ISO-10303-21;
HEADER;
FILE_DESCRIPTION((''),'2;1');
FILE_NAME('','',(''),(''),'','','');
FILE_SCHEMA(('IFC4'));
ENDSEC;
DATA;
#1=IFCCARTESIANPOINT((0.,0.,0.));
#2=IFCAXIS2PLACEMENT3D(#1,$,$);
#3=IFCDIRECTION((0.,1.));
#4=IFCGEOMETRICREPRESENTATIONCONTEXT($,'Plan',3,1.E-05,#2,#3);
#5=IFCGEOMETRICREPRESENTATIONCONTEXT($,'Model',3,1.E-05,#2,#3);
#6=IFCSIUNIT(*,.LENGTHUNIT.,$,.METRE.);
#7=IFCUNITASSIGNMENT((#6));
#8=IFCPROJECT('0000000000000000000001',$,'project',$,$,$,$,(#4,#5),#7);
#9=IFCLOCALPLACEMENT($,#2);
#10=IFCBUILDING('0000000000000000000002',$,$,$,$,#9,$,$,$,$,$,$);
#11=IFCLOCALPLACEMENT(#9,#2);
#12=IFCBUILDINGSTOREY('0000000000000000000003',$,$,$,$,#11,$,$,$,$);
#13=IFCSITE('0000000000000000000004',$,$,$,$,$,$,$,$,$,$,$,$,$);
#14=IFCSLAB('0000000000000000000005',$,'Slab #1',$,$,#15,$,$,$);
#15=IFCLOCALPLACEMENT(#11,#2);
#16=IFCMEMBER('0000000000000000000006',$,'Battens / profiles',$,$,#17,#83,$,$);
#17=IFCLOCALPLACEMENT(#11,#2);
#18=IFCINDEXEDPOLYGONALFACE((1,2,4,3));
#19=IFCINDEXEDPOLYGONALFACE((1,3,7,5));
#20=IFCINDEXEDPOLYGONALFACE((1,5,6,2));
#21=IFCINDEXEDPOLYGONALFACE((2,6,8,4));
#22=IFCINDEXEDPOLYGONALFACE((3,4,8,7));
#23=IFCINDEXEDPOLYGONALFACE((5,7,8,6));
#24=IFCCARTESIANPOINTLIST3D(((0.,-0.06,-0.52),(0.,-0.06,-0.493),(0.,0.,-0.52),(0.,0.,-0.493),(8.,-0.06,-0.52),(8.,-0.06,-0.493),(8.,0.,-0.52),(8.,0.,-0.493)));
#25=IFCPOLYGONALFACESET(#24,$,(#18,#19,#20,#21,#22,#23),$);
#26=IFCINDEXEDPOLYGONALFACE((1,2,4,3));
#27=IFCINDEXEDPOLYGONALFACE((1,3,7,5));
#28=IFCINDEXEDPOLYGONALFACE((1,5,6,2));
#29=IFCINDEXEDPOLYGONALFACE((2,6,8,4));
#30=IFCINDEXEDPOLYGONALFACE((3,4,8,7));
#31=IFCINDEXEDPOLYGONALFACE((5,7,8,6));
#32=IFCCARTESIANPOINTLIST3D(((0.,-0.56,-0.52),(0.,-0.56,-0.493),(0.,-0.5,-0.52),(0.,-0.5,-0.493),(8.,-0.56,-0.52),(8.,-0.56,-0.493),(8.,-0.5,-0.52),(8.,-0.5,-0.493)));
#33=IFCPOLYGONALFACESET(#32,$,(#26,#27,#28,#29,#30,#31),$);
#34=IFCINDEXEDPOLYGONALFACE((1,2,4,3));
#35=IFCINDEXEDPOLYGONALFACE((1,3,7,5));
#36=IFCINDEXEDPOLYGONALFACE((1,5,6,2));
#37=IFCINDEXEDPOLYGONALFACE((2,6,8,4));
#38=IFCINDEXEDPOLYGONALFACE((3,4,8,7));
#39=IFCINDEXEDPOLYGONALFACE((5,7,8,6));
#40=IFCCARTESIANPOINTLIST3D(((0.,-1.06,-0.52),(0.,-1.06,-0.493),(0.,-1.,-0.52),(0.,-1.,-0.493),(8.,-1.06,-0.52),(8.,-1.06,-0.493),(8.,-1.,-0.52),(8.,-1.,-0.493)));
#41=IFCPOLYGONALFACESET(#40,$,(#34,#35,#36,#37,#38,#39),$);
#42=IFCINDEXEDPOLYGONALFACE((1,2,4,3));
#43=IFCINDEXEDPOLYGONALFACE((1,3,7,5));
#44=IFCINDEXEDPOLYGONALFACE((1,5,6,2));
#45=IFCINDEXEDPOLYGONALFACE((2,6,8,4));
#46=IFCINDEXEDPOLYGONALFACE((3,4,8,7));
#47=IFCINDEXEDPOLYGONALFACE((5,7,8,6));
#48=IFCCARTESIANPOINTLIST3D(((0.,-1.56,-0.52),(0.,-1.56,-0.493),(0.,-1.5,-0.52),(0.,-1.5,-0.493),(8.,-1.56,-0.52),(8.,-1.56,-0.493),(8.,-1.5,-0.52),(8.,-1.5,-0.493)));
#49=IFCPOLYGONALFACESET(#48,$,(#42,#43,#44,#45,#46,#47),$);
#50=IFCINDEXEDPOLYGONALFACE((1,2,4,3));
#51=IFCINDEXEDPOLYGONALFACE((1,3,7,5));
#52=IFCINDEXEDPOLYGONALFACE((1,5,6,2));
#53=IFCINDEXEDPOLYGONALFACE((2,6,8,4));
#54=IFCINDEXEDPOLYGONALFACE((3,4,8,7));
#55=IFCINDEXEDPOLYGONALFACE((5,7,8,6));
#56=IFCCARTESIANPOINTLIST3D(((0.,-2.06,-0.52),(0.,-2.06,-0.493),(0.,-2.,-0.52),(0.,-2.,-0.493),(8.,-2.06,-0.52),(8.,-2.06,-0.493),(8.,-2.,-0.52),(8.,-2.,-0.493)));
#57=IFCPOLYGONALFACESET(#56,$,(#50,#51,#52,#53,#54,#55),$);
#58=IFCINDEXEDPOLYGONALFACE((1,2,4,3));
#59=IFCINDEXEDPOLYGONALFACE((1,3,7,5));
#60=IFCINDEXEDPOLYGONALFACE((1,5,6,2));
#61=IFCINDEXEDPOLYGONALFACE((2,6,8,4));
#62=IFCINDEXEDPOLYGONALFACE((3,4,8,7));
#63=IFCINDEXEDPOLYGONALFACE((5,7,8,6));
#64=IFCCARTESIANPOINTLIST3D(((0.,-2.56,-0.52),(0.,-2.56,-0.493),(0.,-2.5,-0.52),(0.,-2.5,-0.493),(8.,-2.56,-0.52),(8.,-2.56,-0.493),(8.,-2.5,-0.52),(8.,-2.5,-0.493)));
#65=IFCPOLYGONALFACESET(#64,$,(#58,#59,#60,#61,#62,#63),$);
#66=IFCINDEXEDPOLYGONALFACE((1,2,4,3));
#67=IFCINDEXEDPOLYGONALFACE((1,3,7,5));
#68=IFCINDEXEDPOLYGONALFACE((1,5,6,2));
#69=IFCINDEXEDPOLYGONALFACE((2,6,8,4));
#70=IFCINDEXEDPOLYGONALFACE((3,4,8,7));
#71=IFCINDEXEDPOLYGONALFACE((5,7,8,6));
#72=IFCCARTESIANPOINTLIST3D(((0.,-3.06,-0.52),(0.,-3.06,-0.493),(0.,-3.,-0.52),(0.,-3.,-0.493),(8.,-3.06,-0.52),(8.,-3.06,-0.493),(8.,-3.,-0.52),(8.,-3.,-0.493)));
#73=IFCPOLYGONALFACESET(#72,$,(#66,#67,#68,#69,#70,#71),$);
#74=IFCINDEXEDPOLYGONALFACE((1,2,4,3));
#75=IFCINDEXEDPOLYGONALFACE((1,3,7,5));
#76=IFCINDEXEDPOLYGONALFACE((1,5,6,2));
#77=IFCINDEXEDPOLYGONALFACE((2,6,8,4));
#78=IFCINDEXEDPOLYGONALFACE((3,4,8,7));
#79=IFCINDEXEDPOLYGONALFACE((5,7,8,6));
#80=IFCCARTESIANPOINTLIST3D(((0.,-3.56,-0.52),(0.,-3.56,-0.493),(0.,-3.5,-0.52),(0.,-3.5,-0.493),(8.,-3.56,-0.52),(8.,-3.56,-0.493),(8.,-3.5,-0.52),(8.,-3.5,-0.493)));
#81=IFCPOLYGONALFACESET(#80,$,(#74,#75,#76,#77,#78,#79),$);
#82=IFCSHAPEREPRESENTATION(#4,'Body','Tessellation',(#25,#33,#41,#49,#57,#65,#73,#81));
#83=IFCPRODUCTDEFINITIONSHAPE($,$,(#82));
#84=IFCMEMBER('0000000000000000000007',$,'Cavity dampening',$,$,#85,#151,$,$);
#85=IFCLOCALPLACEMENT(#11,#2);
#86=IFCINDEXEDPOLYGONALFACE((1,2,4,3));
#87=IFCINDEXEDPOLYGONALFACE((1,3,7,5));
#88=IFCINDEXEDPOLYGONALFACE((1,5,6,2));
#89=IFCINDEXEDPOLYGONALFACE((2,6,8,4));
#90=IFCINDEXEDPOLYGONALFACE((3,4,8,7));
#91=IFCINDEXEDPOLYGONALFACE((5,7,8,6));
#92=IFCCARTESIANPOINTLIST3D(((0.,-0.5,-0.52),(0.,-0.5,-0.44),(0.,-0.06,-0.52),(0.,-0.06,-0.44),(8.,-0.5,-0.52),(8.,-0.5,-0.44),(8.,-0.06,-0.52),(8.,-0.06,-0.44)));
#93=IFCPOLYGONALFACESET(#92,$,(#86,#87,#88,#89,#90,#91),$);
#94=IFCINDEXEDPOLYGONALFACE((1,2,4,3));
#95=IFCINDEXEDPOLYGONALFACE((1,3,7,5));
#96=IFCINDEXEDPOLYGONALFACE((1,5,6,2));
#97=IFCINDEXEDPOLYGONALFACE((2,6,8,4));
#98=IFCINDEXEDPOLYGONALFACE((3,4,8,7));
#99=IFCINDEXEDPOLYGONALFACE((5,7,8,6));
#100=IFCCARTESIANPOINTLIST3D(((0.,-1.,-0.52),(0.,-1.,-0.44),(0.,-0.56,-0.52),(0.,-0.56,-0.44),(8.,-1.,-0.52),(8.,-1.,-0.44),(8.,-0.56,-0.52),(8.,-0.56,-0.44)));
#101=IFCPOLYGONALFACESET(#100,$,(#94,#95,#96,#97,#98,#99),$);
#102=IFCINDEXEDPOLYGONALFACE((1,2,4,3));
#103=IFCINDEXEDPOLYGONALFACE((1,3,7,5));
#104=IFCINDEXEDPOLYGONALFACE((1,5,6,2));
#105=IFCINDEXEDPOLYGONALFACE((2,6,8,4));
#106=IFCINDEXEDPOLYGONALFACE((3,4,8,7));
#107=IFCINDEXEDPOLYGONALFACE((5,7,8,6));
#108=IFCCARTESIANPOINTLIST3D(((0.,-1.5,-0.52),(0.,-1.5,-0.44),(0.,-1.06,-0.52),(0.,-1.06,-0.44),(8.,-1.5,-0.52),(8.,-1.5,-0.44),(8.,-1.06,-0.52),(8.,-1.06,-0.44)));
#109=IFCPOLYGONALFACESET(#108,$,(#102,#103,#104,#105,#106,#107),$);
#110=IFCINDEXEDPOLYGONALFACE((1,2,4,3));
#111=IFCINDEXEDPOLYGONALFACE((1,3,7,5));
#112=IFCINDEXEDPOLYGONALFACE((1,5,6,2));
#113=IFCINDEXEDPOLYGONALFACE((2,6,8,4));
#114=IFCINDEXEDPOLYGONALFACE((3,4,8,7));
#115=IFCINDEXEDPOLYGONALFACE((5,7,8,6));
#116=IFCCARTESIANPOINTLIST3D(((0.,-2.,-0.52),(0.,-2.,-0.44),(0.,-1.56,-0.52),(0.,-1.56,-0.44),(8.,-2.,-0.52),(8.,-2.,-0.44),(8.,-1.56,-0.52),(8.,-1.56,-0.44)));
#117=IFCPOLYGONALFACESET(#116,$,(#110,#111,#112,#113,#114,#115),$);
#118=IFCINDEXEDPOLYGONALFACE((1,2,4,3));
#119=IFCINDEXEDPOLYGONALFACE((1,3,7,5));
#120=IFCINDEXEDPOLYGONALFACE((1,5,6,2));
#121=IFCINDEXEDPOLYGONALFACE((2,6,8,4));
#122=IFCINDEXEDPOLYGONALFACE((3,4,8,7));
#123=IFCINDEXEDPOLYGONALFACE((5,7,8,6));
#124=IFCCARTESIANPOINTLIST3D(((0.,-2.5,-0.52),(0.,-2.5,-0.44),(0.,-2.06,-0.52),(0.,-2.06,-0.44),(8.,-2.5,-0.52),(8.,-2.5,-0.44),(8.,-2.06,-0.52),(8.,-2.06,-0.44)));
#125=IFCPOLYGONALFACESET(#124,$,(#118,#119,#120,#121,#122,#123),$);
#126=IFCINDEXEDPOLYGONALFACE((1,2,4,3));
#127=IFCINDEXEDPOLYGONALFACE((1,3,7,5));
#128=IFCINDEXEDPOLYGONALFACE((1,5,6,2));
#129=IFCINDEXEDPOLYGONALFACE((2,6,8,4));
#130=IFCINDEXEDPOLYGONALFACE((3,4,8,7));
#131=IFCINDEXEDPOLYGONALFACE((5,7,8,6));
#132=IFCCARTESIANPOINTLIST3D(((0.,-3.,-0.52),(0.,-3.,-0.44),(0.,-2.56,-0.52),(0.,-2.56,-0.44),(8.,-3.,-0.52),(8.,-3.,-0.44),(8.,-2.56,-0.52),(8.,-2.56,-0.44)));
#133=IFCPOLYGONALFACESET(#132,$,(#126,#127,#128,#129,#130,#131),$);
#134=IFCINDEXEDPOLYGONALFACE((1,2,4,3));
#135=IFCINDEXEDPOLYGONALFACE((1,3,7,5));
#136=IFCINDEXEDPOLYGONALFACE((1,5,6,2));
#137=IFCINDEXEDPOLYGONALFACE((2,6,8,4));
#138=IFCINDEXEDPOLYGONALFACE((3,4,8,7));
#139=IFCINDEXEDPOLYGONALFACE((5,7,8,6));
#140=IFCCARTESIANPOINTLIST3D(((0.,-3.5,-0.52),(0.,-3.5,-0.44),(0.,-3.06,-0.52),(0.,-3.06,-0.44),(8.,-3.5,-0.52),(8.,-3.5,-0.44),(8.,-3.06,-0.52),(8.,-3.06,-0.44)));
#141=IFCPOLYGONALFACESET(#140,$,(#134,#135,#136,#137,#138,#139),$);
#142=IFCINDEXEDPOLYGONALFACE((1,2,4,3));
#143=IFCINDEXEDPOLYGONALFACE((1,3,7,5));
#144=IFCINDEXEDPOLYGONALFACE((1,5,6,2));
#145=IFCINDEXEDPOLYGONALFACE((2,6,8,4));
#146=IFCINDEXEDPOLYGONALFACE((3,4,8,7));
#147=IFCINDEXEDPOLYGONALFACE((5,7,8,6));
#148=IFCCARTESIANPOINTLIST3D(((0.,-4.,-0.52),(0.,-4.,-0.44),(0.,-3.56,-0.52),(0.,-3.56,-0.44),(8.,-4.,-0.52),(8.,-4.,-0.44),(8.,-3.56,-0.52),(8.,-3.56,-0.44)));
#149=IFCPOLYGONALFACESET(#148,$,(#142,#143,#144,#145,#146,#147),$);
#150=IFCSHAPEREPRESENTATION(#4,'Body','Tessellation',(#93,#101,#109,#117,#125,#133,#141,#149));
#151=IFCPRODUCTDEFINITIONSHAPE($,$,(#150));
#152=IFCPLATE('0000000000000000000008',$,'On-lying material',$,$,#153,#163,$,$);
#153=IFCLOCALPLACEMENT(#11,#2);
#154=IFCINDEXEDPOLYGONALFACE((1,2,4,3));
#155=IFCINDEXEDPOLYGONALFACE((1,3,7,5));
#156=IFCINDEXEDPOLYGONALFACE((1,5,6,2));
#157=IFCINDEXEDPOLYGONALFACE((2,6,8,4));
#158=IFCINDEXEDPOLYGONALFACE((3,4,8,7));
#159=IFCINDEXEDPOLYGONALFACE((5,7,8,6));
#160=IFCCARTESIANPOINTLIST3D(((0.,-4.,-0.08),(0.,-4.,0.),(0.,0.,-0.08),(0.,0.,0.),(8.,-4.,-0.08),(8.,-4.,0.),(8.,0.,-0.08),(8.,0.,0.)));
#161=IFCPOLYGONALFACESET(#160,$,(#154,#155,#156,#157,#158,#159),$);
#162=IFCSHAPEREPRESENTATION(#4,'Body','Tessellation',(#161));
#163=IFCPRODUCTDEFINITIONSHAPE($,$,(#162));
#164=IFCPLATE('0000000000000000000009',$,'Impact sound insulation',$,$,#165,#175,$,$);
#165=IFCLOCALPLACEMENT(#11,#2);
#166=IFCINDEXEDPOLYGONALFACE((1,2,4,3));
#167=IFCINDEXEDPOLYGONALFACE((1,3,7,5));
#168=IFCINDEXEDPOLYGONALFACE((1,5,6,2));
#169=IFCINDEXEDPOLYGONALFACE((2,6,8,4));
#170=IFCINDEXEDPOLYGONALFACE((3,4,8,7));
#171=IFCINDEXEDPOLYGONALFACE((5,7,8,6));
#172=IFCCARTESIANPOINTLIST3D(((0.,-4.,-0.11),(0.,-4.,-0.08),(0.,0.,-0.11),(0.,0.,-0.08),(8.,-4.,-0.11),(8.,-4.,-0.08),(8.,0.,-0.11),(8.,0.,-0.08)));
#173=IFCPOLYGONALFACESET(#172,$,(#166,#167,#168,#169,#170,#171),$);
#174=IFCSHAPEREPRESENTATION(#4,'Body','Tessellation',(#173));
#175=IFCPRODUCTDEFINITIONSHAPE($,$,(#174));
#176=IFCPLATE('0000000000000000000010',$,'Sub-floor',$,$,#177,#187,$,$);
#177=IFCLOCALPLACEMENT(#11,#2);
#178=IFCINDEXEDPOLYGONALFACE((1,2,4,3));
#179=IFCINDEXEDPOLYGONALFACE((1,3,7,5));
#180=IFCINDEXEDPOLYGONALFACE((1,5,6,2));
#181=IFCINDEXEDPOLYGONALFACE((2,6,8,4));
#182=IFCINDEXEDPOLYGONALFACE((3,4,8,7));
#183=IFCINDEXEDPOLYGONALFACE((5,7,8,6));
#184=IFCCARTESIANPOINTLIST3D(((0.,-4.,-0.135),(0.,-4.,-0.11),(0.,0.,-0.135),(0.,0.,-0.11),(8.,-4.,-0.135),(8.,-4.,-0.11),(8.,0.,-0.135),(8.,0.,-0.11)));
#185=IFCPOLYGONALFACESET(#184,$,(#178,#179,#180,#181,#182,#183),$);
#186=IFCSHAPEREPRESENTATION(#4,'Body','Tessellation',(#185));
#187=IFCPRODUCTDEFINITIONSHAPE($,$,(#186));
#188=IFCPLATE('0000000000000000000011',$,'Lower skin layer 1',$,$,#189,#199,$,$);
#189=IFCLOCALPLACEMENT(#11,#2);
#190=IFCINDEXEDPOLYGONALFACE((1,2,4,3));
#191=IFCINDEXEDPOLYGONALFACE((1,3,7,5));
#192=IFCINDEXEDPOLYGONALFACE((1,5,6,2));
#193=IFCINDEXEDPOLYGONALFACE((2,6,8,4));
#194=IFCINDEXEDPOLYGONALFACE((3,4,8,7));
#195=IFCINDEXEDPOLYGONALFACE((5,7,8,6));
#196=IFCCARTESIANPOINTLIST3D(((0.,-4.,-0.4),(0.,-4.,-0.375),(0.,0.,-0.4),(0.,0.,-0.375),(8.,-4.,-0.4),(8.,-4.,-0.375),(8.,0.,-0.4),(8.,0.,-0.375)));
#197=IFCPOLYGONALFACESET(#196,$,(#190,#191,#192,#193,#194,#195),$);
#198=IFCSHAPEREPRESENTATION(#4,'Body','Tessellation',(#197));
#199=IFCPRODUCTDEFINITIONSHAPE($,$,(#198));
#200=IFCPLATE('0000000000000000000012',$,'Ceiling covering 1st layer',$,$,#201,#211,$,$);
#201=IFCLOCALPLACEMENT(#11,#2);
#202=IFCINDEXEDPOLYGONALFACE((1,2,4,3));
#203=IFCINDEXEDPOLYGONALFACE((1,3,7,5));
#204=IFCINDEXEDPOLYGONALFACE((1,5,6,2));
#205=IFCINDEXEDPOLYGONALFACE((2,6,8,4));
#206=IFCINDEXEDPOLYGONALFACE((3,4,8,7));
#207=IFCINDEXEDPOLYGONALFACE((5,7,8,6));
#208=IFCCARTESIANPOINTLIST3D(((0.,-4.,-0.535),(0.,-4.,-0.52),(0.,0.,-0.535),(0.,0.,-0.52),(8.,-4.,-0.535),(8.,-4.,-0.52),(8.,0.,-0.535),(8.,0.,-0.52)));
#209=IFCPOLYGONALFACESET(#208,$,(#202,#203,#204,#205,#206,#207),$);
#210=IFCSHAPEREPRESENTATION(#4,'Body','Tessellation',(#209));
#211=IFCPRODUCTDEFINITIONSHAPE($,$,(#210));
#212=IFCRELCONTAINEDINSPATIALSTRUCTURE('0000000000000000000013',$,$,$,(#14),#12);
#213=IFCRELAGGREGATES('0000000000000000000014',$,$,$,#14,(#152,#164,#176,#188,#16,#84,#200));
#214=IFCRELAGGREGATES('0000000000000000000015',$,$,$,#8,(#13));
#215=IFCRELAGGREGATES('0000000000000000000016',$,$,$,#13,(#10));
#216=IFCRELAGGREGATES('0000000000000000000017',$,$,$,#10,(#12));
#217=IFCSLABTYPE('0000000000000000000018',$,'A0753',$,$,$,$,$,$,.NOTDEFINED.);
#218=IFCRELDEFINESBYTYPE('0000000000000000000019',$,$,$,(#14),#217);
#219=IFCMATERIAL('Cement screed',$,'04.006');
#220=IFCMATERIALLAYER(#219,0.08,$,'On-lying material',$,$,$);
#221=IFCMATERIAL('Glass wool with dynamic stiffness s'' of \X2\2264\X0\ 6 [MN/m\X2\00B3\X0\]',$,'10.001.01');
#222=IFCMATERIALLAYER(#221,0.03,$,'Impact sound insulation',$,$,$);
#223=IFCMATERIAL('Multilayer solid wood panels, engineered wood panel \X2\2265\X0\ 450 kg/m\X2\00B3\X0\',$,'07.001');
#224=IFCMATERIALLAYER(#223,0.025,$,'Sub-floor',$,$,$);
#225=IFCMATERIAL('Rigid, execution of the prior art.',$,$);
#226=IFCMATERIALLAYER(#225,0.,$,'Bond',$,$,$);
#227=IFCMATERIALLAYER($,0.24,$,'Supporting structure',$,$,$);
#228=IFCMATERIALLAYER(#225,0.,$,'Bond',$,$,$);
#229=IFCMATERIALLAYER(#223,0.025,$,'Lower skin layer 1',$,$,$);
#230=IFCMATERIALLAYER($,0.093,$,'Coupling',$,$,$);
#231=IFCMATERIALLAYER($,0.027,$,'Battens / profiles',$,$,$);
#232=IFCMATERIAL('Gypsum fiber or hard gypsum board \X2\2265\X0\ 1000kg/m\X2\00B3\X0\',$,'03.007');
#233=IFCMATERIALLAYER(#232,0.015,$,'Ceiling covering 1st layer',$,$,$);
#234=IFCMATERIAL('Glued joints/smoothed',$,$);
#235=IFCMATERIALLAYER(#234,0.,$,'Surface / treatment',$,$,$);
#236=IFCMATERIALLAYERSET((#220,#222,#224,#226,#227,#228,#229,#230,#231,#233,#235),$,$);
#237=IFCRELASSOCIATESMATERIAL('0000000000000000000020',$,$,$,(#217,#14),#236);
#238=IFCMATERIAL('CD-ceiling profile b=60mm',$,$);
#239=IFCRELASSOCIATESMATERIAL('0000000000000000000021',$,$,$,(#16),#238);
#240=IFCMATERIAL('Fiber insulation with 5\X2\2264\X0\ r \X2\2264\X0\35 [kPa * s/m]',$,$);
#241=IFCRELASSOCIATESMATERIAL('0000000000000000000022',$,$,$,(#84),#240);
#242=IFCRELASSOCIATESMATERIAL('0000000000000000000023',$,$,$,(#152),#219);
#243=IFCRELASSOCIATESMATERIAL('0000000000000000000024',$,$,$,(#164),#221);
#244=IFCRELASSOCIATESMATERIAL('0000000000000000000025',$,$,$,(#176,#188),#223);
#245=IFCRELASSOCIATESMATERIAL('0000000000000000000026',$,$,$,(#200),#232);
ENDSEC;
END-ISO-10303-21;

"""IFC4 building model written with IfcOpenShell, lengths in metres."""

from ifc_helpers import new_model, si_unit, direction, frame, frame_2d, origin, origin_with_axes, place, context, project, spatial, rectangle, extrude, material, layer, layer_set, type_object, element, aggregate, save


model = new_model("IFC4")

# Units and contexts
plan_context = context("Plan", 3, precision=1e-05, world=origin(), true_north=direction((0.0, 1.0)))
model_context = context("Model", 3, precision=1e-05, world=origin(), true_north=direction((0.0, 1.0)))
ifc_project = project(units=[si_unit("LENGTHUNIT", "METRE")], contexts=[plan_context, model_context])

# Site, building, storey
site = spatial("IfcSite", under=ifc_project)
building_placement = place(None, origin())
building = spatial("IfcBuilding", under=site, at=building_placement)
storey_placement = place(building_placement, origin())
storey = spatial("IfcBuildingStorey", under=building, at=storey_placement)

# Slab, members, plates
ifc_material_1 = material(Name="Cement screed", Category="04.006")
ifc_layer_1 = layer(ifc_material_1, 0.08, Name="On-lying material")
ifc_material_2 = material(Name="Glass wool with dynamic stiffness s' of ≤ 6 [MN/m³]", Category="10.001.01")
ifc_layer_2 = layer(ifc_material_2, 0.03, Name="Impact sound insulation")
ifc_material_3 = material(Name="Multilayer solid wood panels, engineered wood panel ≥ 450 kg/m³", Category="07.001")
ifc_layer_3 = layer(ifc_material_3, 0.025, Name="Sub-floor")
ifc_material_4 = material(Name="Rigid, execution of the prior art.")
ifc_layer_4 = layer(ifc_material_4, 0.0, Name="Bond")
ifc_layer_5 = layer(None, 0.24, Name="Supporting structure")
ifc_layer_6 = layer(ifc_material_4, 0.0, Name="Bond")
ifc_layer_7 = layer(ifc_material_3, 0.025, Name="Lower skin layer 1")
ifc_layer_8 = layer(None, 0.093, Name="Coupling")
ifc_layer_9 = layer(None, 0.027, Name="Battens / profiles")
ifc_material_5 = material(Name="Gypsum fiber or hard gypsum board ≥ 1000kg/m³", Category="03.007")
ifc_layer_10 = layer(ifc_material_5, 0.015, Name="Ceiling covering 1st layer")
ifc_material_6 = material(Name="Glued joints/smoothed")
ifc_layer_11 = layer(ifc_material_6, 0.0, Name="Surface / treatment")
ifc_layer_set = layer_set([ifc_layer_1, ifc_layer_2, ifc_layer_3, ifc_layer_4, ifc_layer_5, ifc_layer_6, ifc_layer_7, ifc_layer_8, ifc_layer_9, ifc_layer_10, ifc_layer_11])
slab_type = type_object("IfcSlabType", Name="A0753", PredefinedType="NOTDEFINED", material=ifc_layer_set)
slab_placement = place(None, frame((0.0, 0.0, 0.0), z_axis=(0.0, 0.0, -1.0), x_axis=(1.0, 0.0, 0.0)))
slab = element("IfcSlab", 1, at=slab_placement, inside=storey, type_object=slab_type, material=ifc_layer_set, Name="Slab #1")
ifc_material_7 = material(Name="CD-ceiling profile b=60mm")
member_1_placement = place(slab_placement, origin())
member_1 = element("IfcMember", 2, at=member_1_placement, material=ifc_material_7, Name="Battens / profiles", context=plan_context, shape_type="SweptSolid", body=[
    extrude(rectangle(XDim=0.06, YDim=0.027, at=frame_2d((0.03, 0.0135), x_axis=(1.0, 0.0))), frame((0.0, 0.0, 0.493), z_axis=(1.0, 0.0, 0.0), x_axis=(0.0, 1.0, 0.0)), (0.0, 0.0, 1.0), 8.0),
    extrude(rectangle(XDim=0.06, YDim=0.027, at=frame_2d((0.03, 0.0135), x_axis=(1.0, 0.0))), frame((0.0, 0.5, 0.493), z_axis=(1.0, 0.0, 0.0), x_axis=(0.0, 1.0, 0.0)), (0.0, 0.0, 1.0), 8.0),
    extrude(rectangle(XDim=0.06, YDim=0.027, at=frame_2d((0.03, 0.0135), x_axis=(1.0, 0.0))), frame((0.0, 1.0, 0.493), z_axis=(1.0, 0.0, 0.0), x_axis=(0.0, 1.0, 0.0)), (0.0, 0.0, 1.0), 8.0),
    extrude(rectangle(XDim=0.06, YDim=0.027, at=frame_2d((0.03, 0.0135), x_axis=(1.0, 0.0))), frame((0.0, 1.5, 0.493), z_axis=(1.0, 0.0, 0.0), x_axis=(0.0, 1.0, 0.0)), (0.0, 0.0, 1.0), 8.0),
    extrude(rectangle(XDim=0.06, YDim=0.027, at=frame_2d((0.03, 0.0135), x_axis=(1.0, 0.0))), frame((0.0, 2.0, 0.493), z_axis=(1.0, 0.0, 0.0), x_axis=(0.0, 1.0, 0.0)), (0.0, 0.0, 1.0), 8.0),
    extrude(rectangle(XDim=0.06, YDim=0.027, at=frame_2d((0.03, 0.0135), x_axis=(1.0, 0.0))), frame((0.0, 2.5, 0.493), z_axis=(1.0, 0.0, 0.0), x_axis=(0.0, 1.0, 0.0)), (0.0, 0.0, 1.0), 8.0),
    extrude(rectangle(XDim=0.06, YDim=0.027, at=frame_2d((0.03, 0.0135), x_axis=(1.0, 0.0))), frame((0.0, 3.0, 0.493), z_axis=(1.0, 0.0, 0.0), x_axis=(0.0, 1.0, 0.0)), (0.0, 0.0, 1.0), 8.0),
    extrude(rectangle(XDim=0.06, YDim=0.027, at=frame_2d((0.03, 0.0135), x_axis=(1.0, 0.0))), frame((0.0, 3.5, 0.493), z_axis=(1.0, 0.0, 0.0), x_axis=(0.0, 1.0, 0.0)), (0.0, 0.0, 1.0), 8.0),
])
ifc_material_8 = material(Name="Fiber insulation with 5≤ r ≤35 [kPa * s/m]")
member_2_placement = place(slab_placement, origin())
member_2 = element("IfcMember", 3, at=member_2_placement, material=ifc_material_8, Name="Cavity dampening", context=plan_context, shape_type="SweptSolid", body=[
    extrude(rectangle(XDim=0.44, YDim=0.08, at=frame_2d((0.22, 0.04), x_axis=(1.0, 0.0))), frame((0.0, 0.06, 0.44), z_axis=(1.0, 0.0, 0.0), x_axis=(0.0, 1.0, 0.0)), (0.0, 0.0, 1.0), 8.0),
    extrude(rectangle(XDim=0.44, YDim=0.08, at=frame_2d((0.22, 0.04), x_axis=(1.0, 0.0))), frame((0.0, 0.56, 0.44), z_axis=(1.0, 0.0, 0.0), x_axis=(0.0, 1.0, 0.0)), (0.0, 0.0, 1.0), 8.0),
    extrude(rectangle(XDim=0.44, YDim=0.08, at=frame_2d((0.22, 0.04), x_axis=(1.0, 0.0))), frame((0.0, 1.06, 0.44), z_axis=(1.0, 0.0, 0.0), x_axis=(0.0, 1.0, 0.0)), (0.0, 0.0, 1.0), 8.0),
    extrude(rectangle(XDim=0.44, YDim=0.08, at=frame_2d((0.22, 0.04), x_axis=(1.0, 0.0))), frame((0.0, 1.56, 0.44), z_axis=(1.0, 0.0, 0.0), x_axis=(0.0, 1.0, 0.0)), (0.0, 0.0, 1.0), 8.0),
    extrude(rectangle(XDim=0.44, YDim=0.08, at=frame_2d((0.22, 0.04), x_axis=(1.0, 0.0))), frame((0.0, 2.06, 0.44), z_axis=(1.0, 0.0, 0.0), x_axis=(0.0, 1.0, 0.0)), (0.0, 0.0, 1.0), 8.0),
    extrude(rectangle(XDim=0.44, YDim=0.08, at=frame_2d((0.22, 0.04), x_axis=(1.0, 0.0))), frame((0.0, 2.56, 0.44), z_axis=(1.0, 0.0, 0.0), x_axis=(0.0, 1.0, 0.0)), (0.0, 0.0, 1.0), 8.0),
    extrude(rectangle(XDim=0.44, YDim=0.08, at=frame_2d((0.22, 0.04), x_axis=(1.0, 0.0))), frame((0.0, 3.06, 0.44), z_axis=(1.0, 0.0, 0.0), x_axis=(0.0, 1.0, 0.0)), (0.0, 0.0, 1.0), 8.0),
    extrude(rectangle(XDim=0.44, YDim=0.08, at=frame_2d((0.22, 0.04), x_axis=(1.0, 0.0))), frame((0.0, 3.56, 0.44), z_axis=(1.0, 0.0, 0.0), x_axis=(0.0, 1.0, 0.0)), (0.0, 0.0, 1.0), 8.0),
])
plate_1_placement = place(slab_placement, origin())
plate_1 = element("IfcPlate", 4, at=plate_1_placement, material=ifc_material_1, Name="On-lying material", context=plan_context, shape_type="SweptSolid", body=[
    extrude(rectangle(XDim=8.0, YDim=4.0, at=frame_2d((4.0, 2.0), x_axis=(1.0, 0.0))), origin_with_axes(), (0.0, 0.0, 1.0), 0.08),
])
plate_2_placement = place(slab_placement, origin())
plate_2 = element("IfcPlate", 5, at=plate_2_placement, material=ifc_material_2, Name="Impact sound insulation", context=plan_context, shape_type="SweptSolid", body=[
    extrude(rectangle(XDim=8.0, YDim=4.0, at=frame_2d((4.0, 2.0), x_axis=(1.0, 0.0))), frame((0.0, 0.0, 0.08), z_axis=(0.0, 0.0, 1.0), x_axis=(1.0, 0.0, 0.0)), (0.0, 0.0, 1.0), 0.03),
])
plate_3_placement = place(slab_placement, origin())
plate_3 = element("IfcPlate", 6, at=plate_3_placement, material=ifc_material_3, Name="Sub-floor", context=plan_context, shape_type="SweptSolid", body=[
    extrude(rectangle(XDim=8.0, YDim=4.0, at=frame_2d((4.0, 2.0), x_axis=(1.0, 0.0))), frame((0.0, 0.0, 0.11), z_axis=(0.0, 0.0, 1.0), x_axis=(1.0, 0.0, 0.0)), (0.0, 0.0, 1.0), 0.025),
])
plate_4_placement = place(slab_placement, origin())
plate_4 = element("IfcPlate", 7, at=plate_4_placement, material=ifc_material_3, Name="Lower skin layer 1", context=plan_context, shape_type="SweptSolid", body=[
    extrude(rectangle(XDim=8.0, YDim=4.0, at=frame_2d((4.0, 2.0), x_axis=(1.0, 0.0))), frame((0.0, 0.0, 0.375), z_axis=(0.0, 0.0, 1.0), x_axis=(1.0, 0.0, 0.0)), (0.0, 0.0, 1.0), 0.025),
])
plate_5_placement = place(slab_placement, origin())
plate_5 = element("IfcPlate", 8, at=plate_5_placement, material=ifc_material_5, Name="Ceiling covering 1st layer", context=plan_context, shape_type="SweptSolid", body=[
    extrude(rectangle(XDim=8.0, YDim=4.0, at=frame_2d((4.0, 2.0), x_axis=(1.0, 0.0))), frame((0.0, 0.0, 0.52), z_axis=(0.0, 0.0, 1.0), x_axis=(1.0, 0.0, 0.0)), (0.0, 0.0, 1.0), 0.015),
])
aggregate(slab, [plate_1, plate_2, plate_3, plate_4, member_1, member_2, plate_5])

save(model, "model.ifc")
